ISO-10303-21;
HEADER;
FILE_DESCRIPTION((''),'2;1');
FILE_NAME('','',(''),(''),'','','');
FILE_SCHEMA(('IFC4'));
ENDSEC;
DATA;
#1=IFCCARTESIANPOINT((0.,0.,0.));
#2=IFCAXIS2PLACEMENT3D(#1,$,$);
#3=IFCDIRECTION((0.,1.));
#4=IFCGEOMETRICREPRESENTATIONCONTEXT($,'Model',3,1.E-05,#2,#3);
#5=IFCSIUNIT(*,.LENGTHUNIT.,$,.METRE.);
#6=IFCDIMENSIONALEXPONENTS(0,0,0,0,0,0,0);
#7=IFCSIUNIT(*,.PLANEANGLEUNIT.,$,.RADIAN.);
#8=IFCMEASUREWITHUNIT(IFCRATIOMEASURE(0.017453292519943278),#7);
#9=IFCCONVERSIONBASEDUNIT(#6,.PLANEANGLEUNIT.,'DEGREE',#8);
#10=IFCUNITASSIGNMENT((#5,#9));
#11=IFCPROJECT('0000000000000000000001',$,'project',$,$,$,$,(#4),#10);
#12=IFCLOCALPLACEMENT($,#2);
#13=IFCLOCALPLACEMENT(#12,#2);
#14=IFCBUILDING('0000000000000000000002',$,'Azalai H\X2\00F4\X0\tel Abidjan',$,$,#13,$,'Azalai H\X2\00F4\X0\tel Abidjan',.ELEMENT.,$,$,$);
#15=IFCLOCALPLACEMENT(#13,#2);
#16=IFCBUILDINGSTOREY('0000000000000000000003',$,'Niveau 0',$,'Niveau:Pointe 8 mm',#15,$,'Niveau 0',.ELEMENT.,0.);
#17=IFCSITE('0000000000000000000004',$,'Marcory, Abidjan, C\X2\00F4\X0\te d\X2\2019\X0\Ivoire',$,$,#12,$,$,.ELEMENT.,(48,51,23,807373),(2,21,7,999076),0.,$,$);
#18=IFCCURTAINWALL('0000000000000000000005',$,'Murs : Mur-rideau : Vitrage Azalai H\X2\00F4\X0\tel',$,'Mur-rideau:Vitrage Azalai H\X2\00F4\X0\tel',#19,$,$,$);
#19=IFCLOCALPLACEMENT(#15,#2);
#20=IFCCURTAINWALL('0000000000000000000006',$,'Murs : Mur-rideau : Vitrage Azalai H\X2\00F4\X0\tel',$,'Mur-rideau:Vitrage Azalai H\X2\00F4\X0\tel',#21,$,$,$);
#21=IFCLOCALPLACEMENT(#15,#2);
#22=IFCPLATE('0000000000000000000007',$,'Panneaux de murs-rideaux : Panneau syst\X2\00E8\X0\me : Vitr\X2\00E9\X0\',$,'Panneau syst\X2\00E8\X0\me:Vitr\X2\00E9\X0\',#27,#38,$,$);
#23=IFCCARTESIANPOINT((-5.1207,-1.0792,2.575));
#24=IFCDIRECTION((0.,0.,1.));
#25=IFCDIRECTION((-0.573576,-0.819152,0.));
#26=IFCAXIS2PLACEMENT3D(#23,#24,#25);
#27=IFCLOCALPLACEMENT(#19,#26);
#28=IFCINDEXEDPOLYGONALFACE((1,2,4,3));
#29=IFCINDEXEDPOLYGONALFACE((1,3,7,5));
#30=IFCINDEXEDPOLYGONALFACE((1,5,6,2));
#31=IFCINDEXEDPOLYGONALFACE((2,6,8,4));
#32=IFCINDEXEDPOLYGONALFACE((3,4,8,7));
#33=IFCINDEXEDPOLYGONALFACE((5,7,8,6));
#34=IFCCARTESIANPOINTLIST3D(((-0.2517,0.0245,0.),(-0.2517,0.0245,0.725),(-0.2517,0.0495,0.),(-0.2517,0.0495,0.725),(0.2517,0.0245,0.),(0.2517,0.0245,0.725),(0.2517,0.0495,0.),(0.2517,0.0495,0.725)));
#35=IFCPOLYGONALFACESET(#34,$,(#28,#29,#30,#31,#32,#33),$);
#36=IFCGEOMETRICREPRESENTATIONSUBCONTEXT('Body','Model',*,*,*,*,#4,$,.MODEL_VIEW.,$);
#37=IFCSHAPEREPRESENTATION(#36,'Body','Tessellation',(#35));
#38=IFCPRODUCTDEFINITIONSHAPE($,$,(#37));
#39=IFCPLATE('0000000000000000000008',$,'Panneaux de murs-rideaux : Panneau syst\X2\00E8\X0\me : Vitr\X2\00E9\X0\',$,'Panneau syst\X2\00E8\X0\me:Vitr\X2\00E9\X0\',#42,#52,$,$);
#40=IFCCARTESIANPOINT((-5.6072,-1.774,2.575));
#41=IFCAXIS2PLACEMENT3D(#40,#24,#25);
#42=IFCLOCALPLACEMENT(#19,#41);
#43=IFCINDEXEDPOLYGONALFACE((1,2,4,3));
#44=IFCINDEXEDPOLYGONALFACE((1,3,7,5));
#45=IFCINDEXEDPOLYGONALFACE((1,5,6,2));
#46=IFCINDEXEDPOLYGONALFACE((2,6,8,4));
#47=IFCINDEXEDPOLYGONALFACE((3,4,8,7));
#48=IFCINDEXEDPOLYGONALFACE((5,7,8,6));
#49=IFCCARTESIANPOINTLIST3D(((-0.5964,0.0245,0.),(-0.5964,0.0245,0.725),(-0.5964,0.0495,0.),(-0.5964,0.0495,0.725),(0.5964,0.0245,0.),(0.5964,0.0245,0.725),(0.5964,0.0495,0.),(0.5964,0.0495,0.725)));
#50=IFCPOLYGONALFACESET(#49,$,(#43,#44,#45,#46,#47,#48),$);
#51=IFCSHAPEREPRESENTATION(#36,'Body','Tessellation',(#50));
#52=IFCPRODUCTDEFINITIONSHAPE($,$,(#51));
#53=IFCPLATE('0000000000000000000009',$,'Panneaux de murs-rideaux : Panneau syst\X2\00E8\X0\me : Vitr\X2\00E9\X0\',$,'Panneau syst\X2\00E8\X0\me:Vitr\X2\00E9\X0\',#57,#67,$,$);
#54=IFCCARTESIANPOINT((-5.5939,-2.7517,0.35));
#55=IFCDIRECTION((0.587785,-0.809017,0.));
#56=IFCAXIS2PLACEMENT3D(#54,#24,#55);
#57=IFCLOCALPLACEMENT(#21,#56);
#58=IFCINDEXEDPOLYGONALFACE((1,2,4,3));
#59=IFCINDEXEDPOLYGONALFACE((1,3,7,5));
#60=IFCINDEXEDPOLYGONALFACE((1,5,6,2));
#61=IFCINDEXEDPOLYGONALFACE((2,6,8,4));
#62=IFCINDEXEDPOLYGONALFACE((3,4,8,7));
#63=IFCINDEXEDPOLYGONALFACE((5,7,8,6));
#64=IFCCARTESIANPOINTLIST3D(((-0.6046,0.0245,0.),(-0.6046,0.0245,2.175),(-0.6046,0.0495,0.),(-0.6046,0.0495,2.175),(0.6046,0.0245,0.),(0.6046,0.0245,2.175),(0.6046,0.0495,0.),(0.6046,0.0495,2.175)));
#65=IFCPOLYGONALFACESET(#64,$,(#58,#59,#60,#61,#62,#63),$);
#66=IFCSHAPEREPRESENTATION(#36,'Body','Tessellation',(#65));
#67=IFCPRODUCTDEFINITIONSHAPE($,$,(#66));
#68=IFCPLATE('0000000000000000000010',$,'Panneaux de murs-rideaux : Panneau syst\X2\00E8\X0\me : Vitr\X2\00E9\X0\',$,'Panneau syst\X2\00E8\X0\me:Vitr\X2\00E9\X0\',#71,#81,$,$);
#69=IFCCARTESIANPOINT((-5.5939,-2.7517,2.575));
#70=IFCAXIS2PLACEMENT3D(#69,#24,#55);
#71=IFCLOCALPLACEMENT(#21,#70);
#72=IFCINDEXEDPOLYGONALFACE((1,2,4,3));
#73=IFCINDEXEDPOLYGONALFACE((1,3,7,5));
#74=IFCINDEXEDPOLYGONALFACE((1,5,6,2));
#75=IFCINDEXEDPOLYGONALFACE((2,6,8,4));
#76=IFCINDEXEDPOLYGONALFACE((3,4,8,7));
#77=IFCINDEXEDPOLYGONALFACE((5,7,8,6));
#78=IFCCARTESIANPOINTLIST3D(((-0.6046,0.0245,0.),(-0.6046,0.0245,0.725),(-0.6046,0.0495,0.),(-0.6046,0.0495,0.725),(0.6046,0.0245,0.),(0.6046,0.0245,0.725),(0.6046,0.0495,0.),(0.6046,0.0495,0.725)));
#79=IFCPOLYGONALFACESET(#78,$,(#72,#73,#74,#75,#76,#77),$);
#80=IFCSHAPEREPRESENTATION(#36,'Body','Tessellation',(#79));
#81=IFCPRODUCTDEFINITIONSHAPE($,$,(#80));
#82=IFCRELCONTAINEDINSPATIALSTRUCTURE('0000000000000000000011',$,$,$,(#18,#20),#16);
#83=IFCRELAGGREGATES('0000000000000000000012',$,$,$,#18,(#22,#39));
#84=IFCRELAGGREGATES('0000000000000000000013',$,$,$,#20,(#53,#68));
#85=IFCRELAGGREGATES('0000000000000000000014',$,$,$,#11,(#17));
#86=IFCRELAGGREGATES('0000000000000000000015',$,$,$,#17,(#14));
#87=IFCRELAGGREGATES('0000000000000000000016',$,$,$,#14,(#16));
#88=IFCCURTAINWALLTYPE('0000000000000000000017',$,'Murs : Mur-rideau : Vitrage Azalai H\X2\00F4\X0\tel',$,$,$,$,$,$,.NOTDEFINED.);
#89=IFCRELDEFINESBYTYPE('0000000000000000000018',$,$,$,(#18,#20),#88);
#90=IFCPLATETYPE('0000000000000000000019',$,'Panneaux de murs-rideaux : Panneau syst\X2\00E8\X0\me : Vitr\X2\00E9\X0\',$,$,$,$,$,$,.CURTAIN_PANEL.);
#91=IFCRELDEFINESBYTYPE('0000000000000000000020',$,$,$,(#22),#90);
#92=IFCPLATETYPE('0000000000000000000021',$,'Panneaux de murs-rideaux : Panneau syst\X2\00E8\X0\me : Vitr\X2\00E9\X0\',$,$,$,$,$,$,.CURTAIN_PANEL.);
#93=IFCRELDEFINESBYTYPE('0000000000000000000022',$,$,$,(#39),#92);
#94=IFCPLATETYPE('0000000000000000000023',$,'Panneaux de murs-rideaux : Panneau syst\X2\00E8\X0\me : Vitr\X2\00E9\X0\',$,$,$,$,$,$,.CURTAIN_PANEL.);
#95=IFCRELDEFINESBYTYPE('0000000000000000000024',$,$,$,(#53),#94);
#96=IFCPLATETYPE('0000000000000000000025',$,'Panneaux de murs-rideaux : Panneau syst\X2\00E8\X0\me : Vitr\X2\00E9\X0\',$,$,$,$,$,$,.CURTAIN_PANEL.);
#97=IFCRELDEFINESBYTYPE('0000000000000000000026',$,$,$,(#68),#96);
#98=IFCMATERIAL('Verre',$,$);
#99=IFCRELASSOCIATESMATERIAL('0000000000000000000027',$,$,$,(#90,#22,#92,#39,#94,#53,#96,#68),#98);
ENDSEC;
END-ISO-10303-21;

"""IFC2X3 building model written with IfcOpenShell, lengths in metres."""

from ifc_helpers import new_model, entity, si_unit, converted_unit, direction, frame, frame_2d, origin, origin_2d_with_axis, place, context, subcontext, project, spatial, rectangle, extrude, source, transform, mapped, material, type_object, type_shapes, element, aggregate, save


model = new_model("IFC2X3")

# Units and contexts
model_context = context("Model", 3, precision=1e-05, world=origin(), true_north=direction((0.0, 1.0)))
body_context = subcontext(model_context, "Body", "Model", "MODEL_VIEW")
ifc_project = project(units=[si_unit("LENGTHUNIT", "METRE"), converted_unit("PLANEANGLEUNIT", "DEGREE", entity("IfcRatioMeasure", 0.017453292519943278), si_unit("PLANEANGLEUNIT", "RADIAN"), dimensions=[0, 0, 0, 0, 0, 0, 0])], contexts=[model_context])

# Site, building, storey
site_placement = place(None, origin())
site = spatial("IfcSite", under=ifc_project, at=site_placement, Name="Marcory, Abidjan, Côte d’Ivoire", CompositionType="ELEMENT", RefLatitude=(48, 51, 23, 807373), RefLongitude=(2, 21, 7, 999076), RefElevation=0.0)
building_placement = place(site_placement, origin())
building = spatial("IfcBuilding", under=site, at=building_placement, Name="Azalai Hôtel Abidjan", LongName="Azalai Hôtel Abidjan", CompositionType="ELEMENT")
storey_placement = place(building_placement, origin())
storey = spatial("IfcBuildingStorey", under=building, at=storey_placement, Name="Niveau 0", ObjectType="Niveau:Pointe 8 mm", LongName="Niveau 0", CompositionType="ELEMENT", Elevation=0.0)

# Curtain walls
curtain_wall_type = type_object("IfcCurtainWallType", Name="Murs : Mur-rideau : Vitrage Azalai Hôtel", PredefinedType="NOTDEFINED")
curtain_wall_1_placement = place(storey_placement, origin())
curtain_wall_1 = element("IfcCurtainWall", 1, at=curtain_wall_1_placement, inside=storey, type_object=curtain_wall_type, Name="Murs : Mur-rideau : Vitrage Azalai Hôtel", ObjectType="Mur-rideau:Vitrage Azalai Hôtel")
curtain_wall_2_placement = place(storey_placement, origin())
curtain_wall_2 = element("IfcCurtainWall", 2, at=curtain_wall_2_placement, inside=storey, type_object=curtain_wall_type, Name="Murs : Mur-rideau : Vitrage Azalai Hôtel", ObjectType="Mur-rideau:Vitrage Azalai Hôtel")

# Plates
ifc_material_1 = material(Name="Verre")
plate_type_1 = type_object("IfcPlateType", Name="Panneaux de murs-rideaux : Panneau système : Vitré", PredefinedType="CURTAIN_PANEL", material=ifc_material_1)
shared_shape_1 = source(origin(), body_context, "Body", "SweptSolid", [
    extrude(rectangle(XDim=0.025, YDim=0.5034, at=frame_2d((0.0, 0.0), x_axis=(1.0, 0.0))), frame((0.0, 0.037, 0.0), z_axis=(0.0, 0.0, 1.0), x_axis=(0.0, 1.0, 0.0)), (0.0, 0.0, 1.0), 0.725),
])
type_shapes(plate_type_1, [shared_shape_1])
plate_1_placement = place(curtain_wall_1_placement, frame((-5.1207, -1.0792, 2.575), z_axis=(0.0, 0.0, 1.0), x_axis=(-0.573576, -0.819152, 0.0)))
plate_1 = element("IfcPlate", 3, at=plate_1_placement, type_object=plate_type_1, material=ifc_material_1, Name="Panneaux de murs-rideaux : Panneau système : Vitré", ObjectType="Panneau système:Vitré", context=body_context, shape_type="MappedRepresentation", body=[
    mapped(shared_shape_1, transform((0.0, 0.0, 0.0), scale=1.0)),
])
plate_type_2 = type_object("IfcPlateType", Name="Panneaux de murs-rideaux : Panneau système : Vitré", PredefinedType="CURTAIN_PANEL", material=ifc_material_1)
shared_shape_2 = source(origin(), body_context, "Body", "SweptSolid", [
    extrude(rectangle(XDim=0.025, YDim=1.1929, at=origin_2d_with_axis()), frame((0.0, 0.037, 0.0), z_axis=(0.0, 0.0, 1.0), x_axis=(0.0, 1.0, 0.0)), (0.0, 0.0, 1.0), 0.725),
])
type_shapes(plate_type_2, [shared_shape_2])
plate_2_placement = place(curtain_wall_1_placement, frame((-5.6072, -1.774, 2.575), z_axis=(0.0, 0.0, 1.0), x_axis=(-0.573576, -0.819152, 0.0)))
plate_2 = element("IfcPlate", 4, at=plate_2_placement, type_object=plate_type_2, material=ifc_material_1, Name="Panneaux de murs-rideaux : Panneau système : Vitré", ObjectType="Panneau système:Vitré", context=body_context, shape_type="MappedRepresentation", body=[
    mapped(shared_shape_2, transform((0.0, 0.0, 0.0), scale=1.0)),
])
aggregate(curtain_wall_1, [plate_1, plate_2])
plate_type_3 = type_object("IfcPlateType", Name="Panneaux de murs-rideaux : Panneau système : Vitré", PredefinedType="CURTAIN_PANEL", material=ifc_material_1)
shared_shape_3 = source(origin(), body_context, "Body", "SweptSolid", [
    extrude(rectangle(XDim=0.025, YDim=1.2092, at=frame_2d((0.0, 0.0), x_axis=(1.0, 0.0))), frame((0.0, 0.037, 0.0), z_axis=(0.0, 0.0, 1.0), x_axis=(0.0, 1.0, 0.0)), (0.0, 0.0, 1.0), 2.175),
])
type_shapes(plate_type_3, [shared_shape_3])
plate_3_placement = place(curtain_wall_2_placement, frame((-5.5939, -2.7517, 0.35), z_axis=(0.0, 0.0, 1.0), x_axis=(0.587785, -0.809017, 0.0)))
plate_3 = element("IfcPlate", 5, at=plate_3_placement, type_object=plate_type_3, material=ifc_material_1, Name="Panneaux de murs-rideaux : Panneau système : Vitré", ObjectType="Panneau système:Vitré", context=body_context, shape_type="MappedRepresentation", body=[
    mapped(shared_shape_3, transform((0.0, 0.0, 0.0), scale=1.0)),
])
plate_type_4 = type_object("IfcPlateType", Name="Panneaux de murs-rideaux : Panneau système : Vitré", PredefinedType="CURTAIN_PANEL", material=ifc_material_1)
shared_shape_4 = source(origin(), body_context, "Body", "SweptSolid", [
    extrude(rectangle(XDim=0.025, YDim=1.2092, at=frame_2d((0.0, 0.0), x_axis=(1.0, 0.0))), frame((0.0, 0.037, 0.0), z_axis=(0.0, 0.0, 1.0), x_axis=(0.0, 1.0, 0.0)), (0.0, 0.0, 1.0), 0.725),
])
type_shapes(plate_type_4, [shared_shape_4])
plate_4_placement = place(curtain_wall_2_placement, frame((-5.5939, -2.7517, 2.575), z_axis=(0.0, 0.0, 1.0), x_axis=(0.587785, -0.809017, 0.0)))
plate_4 = element("IfcPlate", 6, at=plate_4_placement, type_object=plate_type_4, material=ifc_material_1, Name="Panneaux de murs-rideaux : Panneau système : Vitré", ObjectType="Panneau système:Vitré", context=body_context, shape_type="MappedRepresentation", body=[
    mapped(shared_shape_4, transform((0.0, 0.0, 0.0), scale=1.0)),
])
aggregate(curtain_wall_2, [plate_3, plate_4])

save(model, "model.ifc")
